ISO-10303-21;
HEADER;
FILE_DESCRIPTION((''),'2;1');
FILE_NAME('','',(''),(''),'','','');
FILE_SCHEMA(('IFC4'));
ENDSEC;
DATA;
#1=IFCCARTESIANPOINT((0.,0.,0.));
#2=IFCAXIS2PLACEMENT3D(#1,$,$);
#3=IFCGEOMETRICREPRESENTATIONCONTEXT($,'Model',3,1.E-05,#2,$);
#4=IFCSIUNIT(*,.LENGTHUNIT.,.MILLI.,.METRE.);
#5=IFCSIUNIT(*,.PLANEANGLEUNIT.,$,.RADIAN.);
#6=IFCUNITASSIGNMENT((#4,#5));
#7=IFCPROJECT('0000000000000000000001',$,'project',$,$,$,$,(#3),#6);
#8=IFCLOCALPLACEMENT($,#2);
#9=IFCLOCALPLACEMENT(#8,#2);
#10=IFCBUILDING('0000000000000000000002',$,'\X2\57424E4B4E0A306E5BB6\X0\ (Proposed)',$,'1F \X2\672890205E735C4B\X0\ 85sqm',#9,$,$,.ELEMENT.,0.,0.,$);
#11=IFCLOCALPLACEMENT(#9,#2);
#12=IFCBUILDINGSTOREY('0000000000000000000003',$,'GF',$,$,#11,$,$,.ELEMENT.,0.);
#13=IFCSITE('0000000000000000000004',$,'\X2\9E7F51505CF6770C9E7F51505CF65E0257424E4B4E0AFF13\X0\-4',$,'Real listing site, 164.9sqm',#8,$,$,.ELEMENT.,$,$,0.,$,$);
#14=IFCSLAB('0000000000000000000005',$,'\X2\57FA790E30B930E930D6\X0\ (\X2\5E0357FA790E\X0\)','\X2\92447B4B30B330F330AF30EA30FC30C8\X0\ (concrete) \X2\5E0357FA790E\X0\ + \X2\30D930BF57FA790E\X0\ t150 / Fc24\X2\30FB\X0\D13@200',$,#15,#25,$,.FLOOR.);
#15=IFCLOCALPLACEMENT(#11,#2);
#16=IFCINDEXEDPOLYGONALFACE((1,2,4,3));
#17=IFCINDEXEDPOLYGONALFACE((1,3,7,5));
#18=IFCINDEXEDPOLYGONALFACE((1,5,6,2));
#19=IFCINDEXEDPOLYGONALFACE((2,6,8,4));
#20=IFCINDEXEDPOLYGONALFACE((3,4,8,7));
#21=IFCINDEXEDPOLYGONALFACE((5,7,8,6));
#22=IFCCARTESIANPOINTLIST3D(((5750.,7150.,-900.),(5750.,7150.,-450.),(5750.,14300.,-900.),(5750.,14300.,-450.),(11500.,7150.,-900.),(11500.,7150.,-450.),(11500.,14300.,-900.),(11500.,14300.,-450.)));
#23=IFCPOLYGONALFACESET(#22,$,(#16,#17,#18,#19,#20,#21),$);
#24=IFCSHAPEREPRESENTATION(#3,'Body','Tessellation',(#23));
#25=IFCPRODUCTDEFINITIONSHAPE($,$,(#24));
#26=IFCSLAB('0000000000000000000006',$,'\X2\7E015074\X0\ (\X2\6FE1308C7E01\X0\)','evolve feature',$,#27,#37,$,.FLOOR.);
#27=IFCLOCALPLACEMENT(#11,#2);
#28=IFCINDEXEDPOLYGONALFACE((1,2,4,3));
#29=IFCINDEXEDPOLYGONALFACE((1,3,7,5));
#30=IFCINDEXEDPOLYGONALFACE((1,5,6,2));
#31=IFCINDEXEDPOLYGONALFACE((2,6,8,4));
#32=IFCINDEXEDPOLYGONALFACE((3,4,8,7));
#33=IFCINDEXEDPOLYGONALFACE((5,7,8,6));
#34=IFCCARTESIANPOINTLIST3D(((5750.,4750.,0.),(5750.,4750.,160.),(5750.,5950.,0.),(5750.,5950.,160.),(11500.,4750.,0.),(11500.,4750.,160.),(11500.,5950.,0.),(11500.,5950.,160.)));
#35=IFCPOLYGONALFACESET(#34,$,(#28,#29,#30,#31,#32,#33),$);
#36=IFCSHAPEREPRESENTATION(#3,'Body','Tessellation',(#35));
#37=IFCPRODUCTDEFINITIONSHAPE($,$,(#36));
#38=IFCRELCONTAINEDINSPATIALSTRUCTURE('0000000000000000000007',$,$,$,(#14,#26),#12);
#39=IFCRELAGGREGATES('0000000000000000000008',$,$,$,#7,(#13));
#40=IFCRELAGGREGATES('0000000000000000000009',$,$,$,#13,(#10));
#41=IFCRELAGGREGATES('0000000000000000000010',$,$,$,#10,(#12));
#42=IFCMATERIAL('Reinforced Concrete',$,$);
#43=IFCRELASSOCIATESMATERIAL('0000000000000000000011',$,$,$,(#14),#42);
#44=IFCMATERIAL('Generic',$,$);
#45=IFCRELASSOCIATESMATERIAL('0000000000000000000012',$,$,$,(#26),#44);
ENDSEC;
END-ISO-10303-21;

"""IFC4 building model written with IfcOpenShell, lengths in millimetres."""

from ifc_helpers import new_model, si_unit, frame, frame_2d, origin, place, context, project, spatial, rectangle, extrude, material, element, save


model = new_model("IFC4")

# Units and contexts
model_context = context("Model", 3, precision=1e-05, world=origin())
ifc_project = project(units=[si_unit("LENGTHUNIT", "METRE", prefix="MILLI"), si_unit("PLANEANGLEUNIT", "RADIAN")], contexts=[model_context])

# Site, building, storey
site_placement = place(None, origin())
site = spatial("IfcSite", under=ifc_project, at=site_placement, Name="鹿児島県鹿児島市坂之上３-4", ObjectType="Real listing site, 164.9sqm", CompositionType="ELEMENT", RefElevation=0.0)
building_placement = place(site_placement, origin())
building = spatial("IfcBuilding", under=site, at=building_placement, Name="坂之上の家 (Proposed)", ObjectType="1F 木造平屋 85sqm", CompositionType="ELEMENT", ElevationOfRefHeight=0.0, ElevationOfTerrain=0.0)
storey_placement = place(building_placement, origin())
storey = spatial("IfcBuildingStorey", under=building, at=storey_placement, Name="GF", CompositionType="ELEMENT", Elevation=0.0)

# Slabs
ifc_material_1 = material(Name="Reinforced Concrete")
slab_1_placement = place(storey_placement, frame((2875.0, 3575.0, -450.0)))
element("IfcSlab", 1, at=slab_1_placement, inside=storey, material=ifc_material_1, Name="基礎スラブ (布基礎)", Description="鉄筋コンクリート (concrete) 布基礎 + ベタ基礎 t150 / Fc24・D13@200", PredefinedType="FLOOR", context=model_context, shape_type="SweptSolid", body=[
    extrude(rectangle(XDim=5750.0, YDim=7150.0, at=frame_2d((2875.0, 3575.0))), frame((2875.0, 3575.0, -450.0)), (0.0, 0.0, 1.0), 450.0),
])
ifc_material_2 = material(Name="Generic")
slab_2_placement = place(storey_placement, frame((2875.0, 2375.0, 0.0)))
element("IfcSlab", 2, at=slab_2_placement, inside=storey, material=ifc_material_2, Name="縁側 (濡れ縁)", Description="evolve feature", PredefinedType="FLOOR", context=model_context, shape_type="SweptSolid", body=[
    extrude(rectangle(XDim=5750.0, YDim=1200.0, at=frame_2d((2875.0, 600.0))), frame((2875.0, 2375.0, 0.0)), (0.0, 0.0, 1.0), 160.0),
])

save(model, "model.ifc")
